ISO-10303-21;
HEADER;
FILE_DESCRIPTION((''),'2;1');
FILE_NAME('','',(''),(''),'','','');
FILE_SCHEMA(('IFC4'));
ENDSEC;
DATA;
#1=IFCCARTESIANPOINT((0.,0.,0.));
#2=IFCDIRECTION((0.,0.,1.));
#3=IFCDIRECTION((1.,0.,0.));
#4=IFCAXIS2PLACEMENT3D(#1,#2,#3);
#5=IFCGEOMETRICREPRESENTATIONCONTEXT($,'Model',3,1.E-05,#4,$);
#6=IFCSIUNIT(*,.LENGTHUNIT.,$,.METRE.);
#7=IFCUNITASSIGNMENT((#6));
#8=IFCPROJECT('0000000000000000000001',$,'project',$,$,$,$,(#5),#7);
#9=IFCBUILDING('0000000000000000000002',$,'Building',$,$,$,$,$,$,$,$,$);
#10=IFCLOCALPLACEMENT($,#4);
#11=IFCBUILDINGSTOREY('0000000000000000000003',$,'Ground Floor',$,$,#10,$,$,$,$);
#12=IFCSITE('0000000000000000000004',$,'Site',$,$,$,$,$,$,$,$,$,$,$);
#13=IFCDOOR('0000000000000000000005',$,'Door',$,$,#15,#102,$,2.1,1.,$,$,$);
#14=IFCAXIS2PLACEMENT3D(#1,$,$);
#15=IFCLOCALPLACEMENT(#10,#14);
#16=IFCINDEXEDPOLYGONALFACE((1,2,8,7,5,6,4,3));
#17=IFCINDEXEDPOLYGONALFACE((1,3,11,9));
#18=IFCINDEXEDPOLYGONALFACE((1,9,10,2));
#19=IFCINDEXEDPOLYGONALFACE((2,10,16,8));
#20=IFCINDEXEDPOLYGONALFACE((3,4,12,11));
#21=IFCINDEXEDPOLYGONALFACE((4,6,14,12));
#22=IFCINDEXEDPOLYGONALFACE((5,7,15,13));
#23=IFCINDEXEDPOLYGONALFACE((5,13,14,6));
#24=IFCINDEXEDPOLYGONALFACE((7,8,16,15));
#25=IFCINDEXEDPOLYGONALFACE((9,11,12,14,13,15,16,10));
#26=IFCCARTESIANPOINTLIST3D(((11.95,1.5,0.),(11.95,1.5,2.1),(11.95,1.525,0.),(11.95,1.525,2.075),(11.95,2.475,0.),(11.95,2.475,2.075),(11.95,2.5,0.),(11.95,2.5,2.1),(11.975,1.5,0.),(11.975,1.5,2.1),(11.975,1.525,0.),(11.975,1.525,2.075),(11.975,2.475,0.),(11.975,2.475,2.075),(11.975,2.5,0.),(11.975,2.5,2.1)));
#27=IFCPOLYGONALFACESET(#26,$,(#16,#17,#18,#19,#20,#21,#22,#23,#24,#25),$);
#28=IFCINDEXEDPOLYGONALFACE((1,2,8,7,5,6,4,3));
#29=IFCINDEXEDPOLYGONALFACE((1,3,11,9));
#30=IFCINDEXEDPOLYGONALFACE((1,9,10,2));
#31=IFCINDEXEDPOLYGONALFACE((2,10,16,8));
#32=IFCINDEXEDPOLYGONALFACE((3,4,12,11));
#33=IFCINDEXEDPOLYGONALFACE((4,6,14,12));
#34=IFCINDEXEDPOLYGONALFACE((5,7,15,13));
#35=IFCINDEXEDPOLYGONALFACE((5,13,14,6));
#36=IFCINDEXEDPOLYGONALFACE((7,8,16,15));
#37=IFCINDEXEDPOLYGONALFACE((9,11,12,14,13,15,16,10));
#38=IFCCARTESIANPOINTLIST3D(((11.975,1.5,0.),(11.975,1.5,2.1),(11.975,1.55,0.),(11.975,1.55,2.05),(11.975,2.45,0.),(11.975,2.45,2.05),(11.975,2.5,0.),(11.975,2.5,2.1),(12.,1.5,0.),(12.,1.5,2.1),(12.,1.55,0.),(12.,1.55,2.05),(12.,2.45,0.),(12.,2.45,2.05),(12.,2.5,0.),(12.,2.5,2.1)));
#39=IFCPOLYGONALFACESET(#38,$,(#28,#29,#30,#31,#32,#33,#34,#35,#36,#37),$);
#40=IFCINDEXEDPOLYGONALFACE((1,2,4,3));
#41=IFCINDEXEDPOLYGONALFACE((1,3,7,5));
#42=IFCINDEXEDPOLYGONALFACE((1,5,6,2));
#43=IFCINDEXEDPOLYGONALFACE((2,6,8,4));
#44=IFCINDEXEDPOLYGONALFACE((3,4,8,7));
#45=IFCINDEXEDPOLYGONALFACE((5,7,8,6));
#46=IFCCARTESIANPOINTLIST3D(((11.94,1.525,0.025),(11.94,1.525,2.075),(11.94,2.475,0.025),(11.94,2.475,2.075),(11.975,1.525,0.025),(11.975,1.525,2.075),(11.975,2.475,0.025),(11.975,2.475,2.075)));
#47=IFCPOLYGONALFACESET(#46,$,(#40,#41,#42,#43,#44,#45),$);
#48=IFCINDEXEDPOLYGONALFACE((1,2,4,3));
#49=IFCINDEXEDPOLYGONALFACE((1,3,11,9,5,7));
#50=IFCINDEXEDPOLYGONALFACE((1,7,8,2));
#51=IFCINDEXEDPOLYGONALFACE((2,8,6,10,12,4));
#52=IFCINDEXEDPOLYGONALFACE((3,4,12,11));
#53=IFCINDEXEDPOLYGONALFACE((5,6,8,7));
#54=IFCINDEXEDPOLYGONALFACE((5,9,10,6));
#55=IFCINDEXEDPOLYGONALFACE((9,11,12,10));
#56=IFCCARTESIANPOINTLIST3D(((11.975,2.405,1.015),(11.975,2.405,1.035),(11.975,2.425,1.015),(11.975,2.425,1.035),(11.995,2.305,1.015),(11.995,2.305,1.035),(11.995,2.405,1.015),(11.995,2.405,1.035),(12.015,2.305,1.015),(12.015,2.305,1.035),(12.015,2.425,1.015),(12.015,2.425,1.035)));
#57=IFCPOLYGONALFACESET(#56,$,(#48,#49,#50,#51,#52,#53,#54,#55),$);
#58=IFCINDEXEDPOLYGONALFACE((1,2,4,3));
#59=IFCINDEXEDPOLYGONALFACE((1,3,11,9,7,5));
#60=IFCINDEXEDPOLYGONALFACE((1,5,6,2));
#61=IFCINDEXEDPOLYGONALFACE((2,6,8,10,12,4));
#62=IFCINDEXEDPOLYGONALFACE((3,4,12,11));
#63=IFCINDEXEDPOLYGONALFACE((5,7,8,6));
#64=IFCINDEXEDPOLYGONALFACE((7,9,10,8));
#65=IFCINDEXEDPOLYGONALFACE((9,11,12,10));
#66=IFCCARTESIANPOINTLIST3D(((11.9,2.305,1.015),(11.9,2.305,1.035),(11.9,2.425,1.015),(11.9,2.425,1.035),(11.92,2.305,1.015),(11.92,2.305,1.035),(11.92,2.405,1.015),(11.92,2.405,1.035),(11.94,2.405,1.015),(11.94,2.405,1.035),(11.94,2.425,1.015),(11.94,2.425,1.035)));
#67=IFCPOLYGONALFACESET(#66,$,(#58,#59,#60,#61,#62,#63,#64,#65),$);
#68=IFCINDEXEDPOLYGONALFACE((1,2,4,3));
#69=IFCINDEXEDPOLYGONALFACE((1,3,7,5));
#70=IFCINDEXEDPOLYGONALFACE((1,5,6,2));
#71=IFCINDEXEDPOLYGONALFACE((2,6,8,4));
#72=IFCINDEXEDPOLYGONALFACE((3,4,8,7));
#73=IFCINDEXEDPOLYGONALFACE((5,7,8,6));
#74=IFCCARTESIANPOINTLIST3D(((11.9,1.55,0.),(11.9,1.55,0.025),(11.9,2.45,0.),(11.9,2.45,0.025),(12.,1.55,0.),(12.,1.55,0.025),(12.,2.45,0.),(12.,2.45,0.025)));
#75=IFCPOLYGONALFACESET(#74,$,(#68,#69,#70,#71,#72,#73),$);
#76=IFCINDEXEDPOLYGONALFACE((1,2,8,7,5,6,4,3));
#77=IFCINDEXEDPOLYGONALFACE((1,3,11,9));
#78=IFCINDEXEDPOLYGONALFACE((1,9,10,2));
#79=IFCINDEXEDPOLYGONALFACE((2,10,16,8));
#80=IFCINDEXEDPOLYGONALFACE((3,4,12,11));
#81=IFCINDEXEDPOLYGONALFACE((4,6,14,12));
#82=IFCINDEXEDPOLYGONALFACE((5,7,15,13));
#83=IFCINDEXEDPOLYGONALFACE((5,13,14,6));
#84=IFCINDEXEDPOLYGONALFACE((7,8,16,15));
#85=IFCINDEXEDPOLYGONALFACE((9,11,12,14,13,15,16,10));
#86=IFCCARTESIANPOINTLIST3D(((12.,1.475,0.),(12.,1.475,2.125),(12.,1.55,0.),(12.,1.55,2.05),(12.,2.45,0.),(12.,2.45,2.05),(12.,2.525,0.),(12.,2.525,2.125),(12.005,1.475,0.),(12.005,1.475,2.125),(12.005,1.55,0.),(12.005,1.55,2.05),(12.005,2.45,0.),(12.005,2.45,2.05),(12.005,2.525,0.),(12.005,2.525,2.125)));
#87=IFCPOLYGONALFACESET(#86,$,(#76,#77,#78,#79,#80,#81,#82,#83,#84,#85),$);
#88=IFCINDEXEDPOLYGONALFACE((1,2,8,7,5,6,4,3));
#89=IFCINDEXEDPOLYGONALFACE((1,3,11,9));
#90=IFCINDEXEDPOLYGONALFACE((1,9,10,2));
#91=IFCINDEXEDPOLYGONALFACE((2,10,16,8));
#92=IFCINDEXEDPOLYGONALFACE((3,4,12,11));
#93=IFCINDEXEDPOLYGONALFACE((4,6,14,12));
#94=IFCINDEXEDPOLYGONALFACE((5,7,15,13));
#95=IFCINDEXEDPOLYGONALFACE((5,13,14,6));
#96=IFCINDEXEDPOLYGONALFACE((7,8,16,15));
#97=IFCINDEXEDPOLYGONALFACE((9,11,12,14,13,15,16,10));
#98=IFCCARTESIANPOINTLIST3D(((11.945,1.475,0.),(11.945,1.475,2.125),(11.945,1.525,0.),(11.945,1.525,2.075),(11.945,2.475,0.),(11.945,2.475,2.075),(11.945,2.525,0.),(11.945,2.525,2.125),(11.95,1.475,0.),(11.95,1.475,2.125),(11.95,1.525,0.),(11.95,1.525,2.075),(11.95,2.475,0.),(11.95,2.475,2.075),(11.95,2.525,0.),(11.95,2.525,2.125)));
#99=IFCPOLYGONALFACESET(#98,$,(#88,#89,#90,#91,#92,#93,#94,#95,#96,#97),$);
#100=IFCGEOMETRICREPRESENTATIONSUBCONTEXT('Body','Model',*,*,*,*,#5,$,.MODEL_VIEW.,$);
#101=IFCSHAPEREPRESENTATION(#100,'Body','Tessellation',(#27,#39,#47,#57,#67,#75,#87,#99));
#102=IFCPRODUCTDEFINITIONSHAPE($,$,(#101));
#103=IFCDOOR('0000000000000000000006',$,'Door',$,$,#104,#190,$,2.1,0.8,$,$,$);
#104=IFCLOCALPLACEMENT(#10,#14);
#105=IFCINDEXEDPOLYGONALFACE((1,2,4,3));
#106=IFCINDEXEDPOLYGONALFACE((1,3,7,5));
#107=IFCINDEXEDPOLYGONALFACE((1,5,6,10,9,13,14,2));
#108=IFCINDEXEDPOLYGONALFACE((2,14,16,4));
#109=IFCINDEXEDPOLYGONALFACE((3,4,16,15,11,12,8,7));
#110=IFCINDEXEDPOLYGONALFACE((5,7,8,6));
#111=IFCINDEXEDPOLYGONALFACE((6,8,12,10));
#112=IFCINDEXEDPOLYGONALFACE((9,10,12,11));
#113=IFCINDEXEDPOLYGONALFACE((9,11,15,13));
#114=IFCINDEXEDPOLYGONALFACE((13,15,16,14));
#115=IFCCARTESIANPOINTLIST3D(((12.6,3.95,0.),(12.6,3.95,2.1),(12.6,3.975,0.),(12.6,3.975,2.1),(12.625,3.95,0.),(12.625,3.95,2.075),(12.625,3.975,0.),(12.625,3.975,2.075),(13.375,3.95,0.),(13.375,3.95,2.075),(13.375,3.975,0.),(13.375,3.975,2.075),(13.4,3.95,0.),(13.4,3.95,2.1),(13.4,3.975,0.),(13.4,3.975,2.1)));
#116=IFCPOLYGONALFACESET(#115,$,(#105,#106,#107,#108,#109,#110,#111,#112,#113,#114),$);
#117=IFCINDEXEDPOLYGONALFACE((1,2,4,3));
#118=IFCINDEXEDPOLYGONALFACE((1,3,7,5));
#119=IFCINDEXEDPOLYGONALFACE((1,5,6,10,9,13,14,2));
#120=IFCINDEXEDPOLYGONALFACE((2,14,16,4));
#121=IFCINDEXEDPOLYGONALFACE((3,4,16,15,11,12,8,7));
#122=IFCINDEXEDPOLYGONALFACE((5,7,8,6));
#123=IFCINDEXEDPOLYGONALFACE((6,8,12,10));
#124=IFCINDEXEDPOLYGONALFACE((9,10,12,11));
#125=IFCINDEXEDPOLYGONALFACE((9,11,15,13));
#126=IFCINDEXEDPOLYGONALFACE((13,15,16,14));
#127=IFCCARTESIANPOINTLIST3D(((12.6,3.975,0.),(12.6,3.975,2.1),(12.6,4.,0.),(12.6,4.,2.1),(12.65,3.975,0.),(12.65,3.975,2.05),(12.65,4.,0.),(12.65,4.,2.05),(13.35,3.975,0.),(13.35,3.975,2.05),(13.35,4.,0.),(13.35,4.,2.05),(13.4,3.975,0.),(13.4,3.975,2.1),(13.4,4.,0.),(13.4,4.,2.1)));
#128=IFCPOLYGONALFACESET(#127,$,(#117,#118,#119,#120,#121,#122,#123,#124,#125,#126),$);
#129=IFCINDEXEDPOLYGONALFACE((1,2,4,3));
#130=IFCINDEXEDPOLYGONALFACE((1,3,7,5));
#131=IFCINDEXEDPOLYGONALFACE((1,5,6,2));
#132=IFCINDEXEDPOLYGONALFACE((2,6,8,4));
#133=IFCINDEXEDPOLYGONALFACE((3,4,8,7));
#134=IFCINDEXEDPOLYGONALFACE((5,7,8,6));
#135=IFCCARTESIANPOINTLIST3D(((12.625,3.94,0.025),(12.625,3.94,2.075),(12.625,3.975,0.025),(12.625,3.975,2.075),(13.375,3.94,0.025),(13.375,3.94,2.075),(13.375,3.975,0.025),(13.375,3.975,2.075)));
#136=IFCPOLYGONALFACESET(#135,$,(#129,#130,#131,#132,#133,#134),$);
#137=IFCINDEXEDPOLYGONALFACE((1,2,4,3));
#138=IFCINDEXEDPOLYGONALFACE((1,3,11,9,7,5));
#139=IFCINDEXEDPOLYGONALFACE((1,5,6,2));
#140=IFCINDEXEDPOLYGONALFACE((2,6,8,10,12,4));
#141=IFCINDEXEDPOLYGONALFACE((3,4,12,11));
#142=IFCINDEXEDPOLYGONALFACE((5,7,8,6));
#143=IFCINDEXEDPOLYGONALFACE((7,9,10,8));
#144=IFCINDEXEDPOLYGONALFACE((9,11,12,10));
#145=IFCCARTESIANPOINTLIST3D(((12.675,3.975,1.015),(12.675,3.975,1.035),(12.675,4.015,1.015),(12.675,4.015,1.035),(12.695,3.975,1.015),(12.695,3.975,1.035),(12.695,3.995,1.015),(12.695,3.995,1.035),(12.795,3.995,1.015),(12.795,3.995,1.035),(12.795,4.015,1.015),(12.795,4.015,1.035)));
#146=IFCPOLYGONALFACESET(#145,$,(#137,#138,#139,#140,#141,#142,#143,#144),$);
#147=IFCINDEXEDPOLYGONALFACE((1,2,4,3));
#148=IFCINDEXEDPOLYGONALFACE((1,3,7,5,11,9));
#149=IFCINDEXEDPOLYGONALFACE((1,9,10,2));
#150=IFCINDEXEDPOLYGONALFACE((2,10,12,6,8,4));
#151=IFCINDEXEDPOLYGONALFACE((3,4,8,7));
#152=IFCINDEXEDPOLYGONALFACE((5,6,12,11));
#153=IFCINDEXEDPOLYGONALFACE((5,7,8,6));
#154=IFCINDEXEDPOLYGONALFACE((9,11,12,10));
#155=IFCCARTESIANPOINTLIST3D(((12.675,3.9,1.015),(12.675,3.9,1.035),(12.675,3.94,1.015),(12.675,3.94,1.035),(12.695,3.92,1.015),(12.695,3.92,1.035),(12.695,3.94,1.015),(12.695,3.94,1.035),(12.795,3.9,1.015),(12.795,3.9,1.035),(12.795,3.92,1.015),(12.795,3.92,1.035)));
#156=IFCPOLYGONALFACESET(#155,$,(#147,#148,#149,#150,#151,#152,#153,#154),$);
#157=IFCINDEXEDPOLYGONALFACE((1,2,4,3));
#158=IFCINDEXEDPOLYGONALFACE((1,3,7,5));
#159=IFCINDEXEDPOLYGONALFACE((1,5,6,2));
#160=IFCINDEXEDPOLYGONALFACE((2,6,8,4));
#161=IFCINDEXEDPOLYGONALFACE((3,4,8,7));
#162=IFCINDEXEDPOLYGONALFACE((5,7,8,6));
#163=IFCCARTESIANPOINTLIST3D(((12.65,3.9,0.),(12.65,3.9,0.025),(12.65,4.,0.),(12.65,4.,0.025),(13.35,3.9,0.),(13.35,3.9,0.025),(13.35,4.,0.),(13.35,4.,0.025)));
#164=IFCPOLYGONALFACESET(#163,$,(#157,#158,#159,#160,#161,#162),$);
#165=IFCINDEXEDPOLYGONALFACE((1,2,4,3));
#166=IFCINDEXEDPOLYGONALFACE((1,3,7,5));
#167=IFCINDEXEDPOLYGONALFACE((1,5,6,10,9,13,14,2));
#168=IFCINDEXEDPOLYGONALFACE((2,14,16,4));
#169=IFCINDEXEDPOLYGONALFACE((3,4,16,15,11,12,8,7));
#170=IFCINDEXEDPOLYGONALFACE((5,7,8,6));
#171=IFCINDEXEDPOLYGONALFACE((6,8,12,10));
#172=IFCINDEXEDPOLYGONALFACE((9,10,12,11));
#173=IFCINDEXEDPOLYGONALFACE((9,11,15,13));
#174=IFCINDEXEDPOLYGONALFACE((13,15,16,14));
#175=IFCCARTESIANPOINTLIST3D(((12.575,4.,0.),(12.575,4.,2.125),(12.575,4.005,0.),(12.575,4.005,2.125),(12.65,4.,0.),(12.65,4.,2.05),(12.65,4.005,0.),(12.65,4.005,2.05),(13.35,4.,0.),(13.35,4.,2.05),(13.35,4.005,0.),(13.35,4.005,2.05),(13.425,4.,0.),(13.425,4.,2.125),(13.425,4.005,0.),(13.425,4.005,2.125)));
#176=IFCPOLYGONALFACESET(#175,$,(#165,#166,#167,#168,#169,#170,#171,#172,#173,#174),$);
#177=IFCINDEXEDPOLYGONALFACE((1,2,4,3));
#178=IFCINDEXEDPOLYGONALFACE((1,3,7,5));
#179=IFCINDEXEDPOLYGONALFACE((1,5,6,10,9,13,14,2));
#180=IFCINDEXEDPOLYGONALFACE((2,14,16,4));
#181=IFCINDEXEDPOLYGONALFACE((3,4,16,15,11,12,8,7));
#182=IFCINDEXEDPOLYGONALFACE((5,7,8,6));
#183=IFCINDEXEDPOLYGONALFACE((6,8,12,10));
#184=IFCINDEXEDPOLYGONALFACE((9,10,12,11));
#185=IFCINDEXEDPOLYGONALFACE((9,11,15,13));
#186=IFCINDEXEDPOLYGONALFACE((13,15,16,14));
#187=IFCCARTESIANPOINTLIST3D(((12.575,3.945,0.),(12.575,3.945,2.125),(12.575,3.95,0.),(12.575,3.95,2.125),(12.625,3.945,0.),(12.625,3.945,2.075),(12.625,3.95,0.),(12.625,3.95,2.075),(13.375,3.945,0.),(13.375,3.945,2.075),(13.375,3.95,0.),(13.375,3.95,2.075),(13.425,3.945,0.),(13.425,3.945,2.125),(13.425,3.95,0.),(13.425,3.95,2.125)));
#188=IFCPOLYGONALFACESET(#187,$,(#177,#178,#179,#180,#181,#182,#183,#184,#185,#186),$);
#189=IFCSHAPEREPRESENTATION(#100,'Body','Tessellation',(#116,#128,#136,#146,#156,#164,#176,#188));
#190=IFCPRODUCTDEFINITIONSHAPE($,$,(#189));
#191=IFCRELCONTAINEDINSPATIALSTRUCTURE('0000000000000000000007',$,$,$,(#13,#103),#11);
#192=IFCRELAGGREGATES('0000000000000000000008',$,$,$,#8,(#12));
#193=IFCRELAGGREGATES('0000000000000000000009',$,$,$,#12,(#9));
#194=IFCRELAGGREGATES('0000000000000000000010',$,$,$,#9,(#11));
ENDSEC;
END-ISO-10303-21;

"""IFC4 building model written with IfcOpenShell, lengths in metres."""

from ifc_helpers import new_model, si_unit, frame, origin_with_axes, place, context, subcontext, project, spatial, line, indexed_curve, outline, extrude, element, save


model = new_model("IFC4")

# Units and contexts
model_context = context("Model", 3, precision=1e-05, world=origin_with_axes())
body_context = subcontext(model_context, "Body", "Model", "MODEL_VIEW")
ifc_project = project(units=[si_unit("LENGTHUNIT", "METRE")], contexts=[model_context])

# Site, building, storey
site = spatial("IfcSite", under=ifc_project, Name="Site")
building = spatial("IfcBuilding", under=site, Name="Building")
storey_placement = place(None, origin_with_axes())
storey = spatial("IfcBuildingStorey", under=building, at=storey_placement, Name="Ground Floor")

# Doors
door_1_placement = place(storey_placement, frame((12.0, 1.5, 0.0), z_axis=(0.0, 0.0, 1.0), x_axis=(0.0, 1.0, 0.0)))
element("IfcDoor", 1, at=door_1_placement, inside=storey, Name="Door", OverallHeight=2.1, OverallWidth=1.0, context=body_context, shape_type="SweptSolid", body=[
    extrude(outline(indexed_curve([(0.0, 0.0), (0.0, 2.1), (1.0, 2.1), (1.0, 0.0), (0.975, 0.0), (0.975, 2.075), (0.025, 2.075), (0.025, 0.0)], segments=[line(1, 2, 3, 4, 5, 6, 7, 8, 1)])), frame((0.0, 0.025, 0.0), z_axis=(0.0, -1.0, 0.0), x_axis=(1.0, 0.0, 0.0)), (0.0, 0.0, -1.0), 0.025),
    extrude(outline(indexed_curve([(0.0, 0.0), (0.0, 2.1), (1.0, 2.1), (1.0, 0.0), (0.95, 0.0), (0.95, 2.05), (0.05, 2.05), (0.05, 0.0)], segments=[line(1, 2, 3, 4, 5, 6, 7, 8, 1)])), frame((0.0, 0.0, 0.0), z_axis=(0.0, -1.0, 0.0), x_axis=(1.0, 0.0, 0.0)), (0.0, 0.0, -1.0), 0.025),
    extrude(outline(indexed_curve([(0.0, 0.0), (0.95, 0.0), (0.95, 0.035), (0.0, 0.035)], segments=[line(1, 2, 3, 4, 1)])), frame((0.025, 0.025, 0.025), z_axis=(0.0, 0.0, 1.0), x_axis=(1.0, 0.0, 0.0)), (0.0, 0.0, 1.0), 2.05),
    extrude(outline(indexed_curve([(0.0, 0.0), (0.0, -0.04), (-0.12, -0.04), (-0.12, -0.02), (-0.02, -0.02), (-0.02, 0.0)], segments=[line(1, 2, 3, 4, 5, 6, 1)])), frame((0.925, 0.025, 1.015), z_axis=(0.0, 0.0, 1.0), x_axis=(1.0, 0.0, 0.0)), (0.0, 0.0, 1.0), 0.02),
    extrude(outline(indexed_curve([(0.0, 0.0), (0.0, 0.04), (-0.12, 0.04), (-0.12, 0.02), (-0.02, 0.02), (-0.02, 0.0)], segments=[line(1, 2, 3, 4, 5, 6, 1)])), frame((0.925, 0.06, 1.015), z_axis=(0.0, 0.0, 1.0), x_axis=(1.0, 0.0, 0.0)), (0.0, 0.0, 1.0), 0.02),
    extrude(outline(indexed_curve([(0.0, 0.0), (0.9, 0.0), (0.9, 0.1), (0.0, 0.1)], segments=[line(1, 2, 3, 4, 1)])), frame((0.05, 0.0, 0.0), z_axis=(0.0, 0.0, 1.0), x_axis=(1.0, 0.0, 0.0)), (0.0, 0.0, 1.0), 0.025),
    extrude(outline(indexed_curve([(0.0, 0.0), (0.0, 2.125), (1.05, 2.125), (1.05, 0.0), (0.975, 0.0), (0.975, 2.05), (0.075, 2.05), (0.075, 0.0)], segments=[line(1, 2, 3, 4, 5, 6, 7, 8, 1)])), frame((-0.025, -0.005, 0.0), z_axis=(0.0, -1.0, 0.0), x_axis=(1.0, 0.0, 0.0)), (0.0, 0.0, -1.0), 0.005),
    extrude(outline(indexed_curve([(0.0, 0.0), (0.0, 2.125), (1.05, 2.125), (1.05, 0.0), (1.0, 0.0), (1.0, 2.075), (0.05, 2.075), (0.05, 0.0)], segments=[line(1, 2, 3, 4, 5, 6, 7, 8, 1)])), frame((-0.025, 0.05, 0.0), z_axis=(0.0, -1.0, 0.0), x_axis=(1.0, 0.0, 0.0)), (0.0, 0.0, -1.0), 0.005),
])
door_2_placement = place(storey_placement, frame((13.4, 4.0, 0.0), z_axis=(0.0, 0.0, 1.0), x_axis=(-1.0, 0.0, 0.0)))
element("IfcDoor", 2, at=door_2_placement, inside=storey, Name="Door", OverallHeight=2.1, OverallWidth=0.8, context=body_context, shape_type="SweptSolid", body=[
    extrude(outline(indexed_curve([(0.0, 0.0), (0.0, 2.1), (0.8, 2.1), (0.8, 0.0), (0.775, 0.0), (0.775, 2.075), (0.025, 2.075), (0.025, 0.0)], segments=[line(1, 2, 3, 4, 5, 6, 7, 8, 1)])), frame((0.0, 0.025, 0.0), z_axis=(0.0, -1.0, 0.0), x_axis=(1.0, 0.0, 0.0)), (0.0, 0.0, -1.0), 0.025),
    extrude(outline(indexed_curve([(0.0, 0.0), (0.0, 2.1), (0.8, 2.1), (0.8, 0.0), (0.75, 0.0), (0.75, 2.05), (0.05, 2.05), (0.05, 0.0)], segments=[line(1, 2, 3, 4, 5, 6, 7, 8, 1)])), frame((0.0, 0.0, 0.0), z_axis=(0.0, -1.0, 0.0), x_axis=(1.0, 0.0, 0.0)), (0.0, 0.0, -1.0), 0.025),
    extrude(outline(indexed_curve([(0.0, 0.0), (0.75, 0.0), (0.75, 0.035), (0.0, 0.035)], segments=[line(1, 2, 3, 4, 1)])), frame((0.025, 0.025, 0.025), z_axis=(0.0, 0.0, 1.0), x_axis=(1.0, 0.0, 0.0)), (0.0, 0.0, 1.0), 2.05),
    extrude(outline(indexed_curve([(0.0, 0.0), (0.0, -0.04), (-0.12, -0.04), (-0.12, -0.02), (-0.02, -0.02), (-0.02, 0.0)], segments=[line(1, 2, 3, 4, 5, 6, 1)])), frame((0.725, 0.025, 1.015), z_axis=(0.0, 0.0, 1.0), x_axis=(1.0, 0.0, 0.0)), (0.0, 0.0, 1.0), 0.02),
    extrude(outline(indexed_curve([(0.0, 0.0), (0.0, 0.04), (-0.12, 0.04), (-0.12, 0.02), (-0.02, 0.02), (-0.02, 0.0)], segments=[line(1, 2, 3, 4, 5, 6, 1)])), frame((0.725, 0.06, 1.015), z_axis=(0.0, 0.0, 1.0), x_axis=(1.0, 0.0, 0.0)), (0.0, 0.0, 1.0), 0.02),
    extrude(outline(indexed_curve([(0.0, 0.0), (0.7, 0.0), (0.7, 0.1), (0.0, 0.1)], segments=[line(1, 2, 3, 4, 1)])), frame((0.05, 0.0, 0.0), z_axis=(0.0, 0.0, 1.0), x_axis=(1.0, 0.0, 0.0)), (0.0, 0.0, 1.0), 0.025),
    extrude(outline(indexed_curve([(0.0, 0.0), (0.0, 2.125), (0.85, 2.125), (0.85, 0.0), (0.775, 0.0), (0.775, 2.05), (0.075, 2.05), (0.075, 0.0)], segments=[line(1, 2, 3, 4, 5, 6, 7, 8, 1)])), frame((-0.025, -0.005, 0.0), z_axis=(0.0, -1.0, 0.0), x_axis=(1.0, 0.0, 0.0)), (0.0, 0.0, -1.0), 0.005),
    extrude(outline(indexed_curve([(0.0, 0.0), (0.0, 2.125), (0.85, 2.125), (0.85, 0.0), (0.8, 0.0), (0.8, 2.075), (0.05, 2.075), (0.05, 0.0)], segments=[line(1, 2, 3, 4, 5, 6, 7, 8, 1)])), frame((-0.025, 0.05, 0.0), z_axis=(0.0, -1.0, 0.0), x_axis=(1.0, 0.0, 0.0)), (0.0, 0.0, -1.0), 0.005),
])

save(model, "model.ifc")
